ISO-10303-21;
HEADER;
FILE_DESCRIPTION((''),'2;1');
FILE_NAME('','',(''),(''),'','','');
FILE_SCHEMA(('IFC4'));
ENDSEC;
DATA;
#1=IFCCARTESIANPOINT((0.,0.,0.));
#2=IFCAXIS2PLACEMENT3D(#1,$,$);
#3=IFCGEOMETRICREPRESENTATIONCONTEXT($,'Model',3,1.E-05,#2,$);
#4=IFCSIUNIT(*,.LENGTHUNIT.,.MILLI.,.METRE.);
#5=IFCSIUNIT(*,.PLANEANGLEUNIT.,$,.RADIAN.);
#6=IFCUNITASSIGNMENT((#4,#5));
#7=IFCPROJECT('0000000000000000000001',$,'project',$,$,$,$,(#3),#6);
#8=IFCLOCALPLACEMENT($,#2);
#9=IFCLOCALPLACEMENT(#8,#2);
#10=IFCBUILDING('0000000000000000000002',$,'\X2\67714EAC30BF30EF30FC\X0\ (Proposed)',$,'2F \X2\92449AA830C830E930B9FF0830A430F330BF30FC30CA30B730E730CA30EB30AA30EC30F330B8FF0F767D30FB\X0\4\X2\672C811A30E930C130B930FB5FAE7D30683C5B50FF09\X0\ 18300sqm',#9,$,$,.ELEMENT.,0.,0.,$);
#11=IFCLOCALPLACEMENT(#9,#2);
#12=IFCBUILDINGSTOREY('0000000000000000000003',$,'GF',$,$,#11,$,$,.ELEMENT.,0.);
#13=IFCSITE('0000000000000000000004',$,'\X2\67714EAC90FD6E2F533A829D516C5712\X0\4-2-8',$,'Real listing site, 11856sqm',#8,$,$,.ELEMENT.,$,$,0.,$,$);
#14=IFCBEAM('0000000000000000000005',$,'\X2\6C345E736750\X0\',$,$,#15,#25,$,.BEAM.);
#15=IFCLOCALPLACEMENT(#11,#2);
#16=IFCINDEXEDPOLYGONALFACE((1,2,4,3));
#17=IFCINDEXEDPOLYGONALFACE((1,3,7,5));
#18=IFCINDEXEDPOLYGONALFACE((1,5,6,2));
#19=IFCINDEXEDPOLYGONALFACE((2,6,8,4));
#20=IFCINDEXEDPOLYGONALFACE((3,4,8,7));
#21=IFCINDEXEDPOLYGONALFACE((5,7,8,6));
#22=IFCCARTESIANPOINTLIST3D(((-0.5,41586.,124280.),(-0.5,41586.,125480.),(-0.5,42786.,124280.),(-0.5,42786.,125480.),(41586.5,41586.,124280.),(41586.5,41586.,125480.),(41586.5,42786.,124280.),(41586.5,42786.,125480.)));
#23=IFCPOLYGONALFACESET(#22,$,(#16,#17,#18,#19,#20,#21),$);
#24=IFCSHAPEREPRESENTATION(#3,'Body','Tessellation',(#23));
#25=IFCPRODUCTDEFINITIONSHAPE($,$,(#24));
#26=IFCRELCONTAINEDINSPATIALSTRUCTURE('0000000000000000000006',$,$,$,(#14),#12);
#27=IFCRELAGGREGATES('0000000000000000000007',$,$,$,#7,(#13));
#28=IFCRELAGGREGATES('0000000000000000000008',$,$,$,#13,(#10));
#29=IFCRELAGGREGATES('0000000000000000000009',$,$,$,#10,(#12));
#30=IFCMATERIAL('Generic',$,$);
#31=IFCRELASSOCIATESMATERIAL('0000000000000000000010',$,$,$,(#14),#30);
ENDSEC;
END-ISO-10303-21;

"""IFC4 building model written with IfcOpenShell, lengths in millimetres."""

from ifc_helpers import new_model, si_unit, frame, frame_2d, origin, place, context, project, spatial, rectangle, extrude, material, element, save


model = new_model("IFC4")

# Units and contexts
model_context = context("Model", 3, precision=1e-05, world=origin())
ifc_project = project(units=[si_unit("LENGTHUNIT", "METRE", prefix="MILLI"), si_unit("PLANEANGLEUNIT", "RADIAN")], contexts=[model_context])

# Site, building, storey
site_placement = place(None, origin())
site = spatial("IfcSite", under=ifc_project, at=site_placement, Name="東京都港区芝公園4-2-8", ObjectType="Real listing site, 11856sqm", CompositionType="ELEMENT", RefElevation=0.0)
building_placement = place(site_placement, origin())
building = spatial("IfcBuilding", under=site, at=building_placement, Name="東京タワー (Proposed)", ObjectType="2F 鉄骨トラス（インターナショナルオレンジ／白・4本脚ラチス・微細格子） 18300sqm", CompositionType="ELEMENT", ElevationOfRefHeight=0.0, ElevationOfTerrain=0.0)
storey_placement = place(building_placement, origin())
storey = spatial("IfcBuildingStorey", under=building, at=storey_placement, Name="GF", CompositionType="ELEMENT", Elevation=0.0)

# Shared definitions
ifc_material = material(Name="Generic")

# Beam
beam_placement = place(storey_placement, frame((0.0, 20793.0, 62140.0)))
element("IfcBeam", 1, at=beam_placement, inside=storey, material=ifc_material, Name="水平材", PredefinedType="BEAM", context=model_context, shape_type="SweptSolid", body=[
    extrude(rectangle(XDim=41587.0, YDim=1200.0, at=frame_2d((20793.0, 600.0))), frame((0.0, 20793.0, 62140.0)), (0.0, 0.0, 1.0), 1200.0),
])

save(model, "model.ifc")
